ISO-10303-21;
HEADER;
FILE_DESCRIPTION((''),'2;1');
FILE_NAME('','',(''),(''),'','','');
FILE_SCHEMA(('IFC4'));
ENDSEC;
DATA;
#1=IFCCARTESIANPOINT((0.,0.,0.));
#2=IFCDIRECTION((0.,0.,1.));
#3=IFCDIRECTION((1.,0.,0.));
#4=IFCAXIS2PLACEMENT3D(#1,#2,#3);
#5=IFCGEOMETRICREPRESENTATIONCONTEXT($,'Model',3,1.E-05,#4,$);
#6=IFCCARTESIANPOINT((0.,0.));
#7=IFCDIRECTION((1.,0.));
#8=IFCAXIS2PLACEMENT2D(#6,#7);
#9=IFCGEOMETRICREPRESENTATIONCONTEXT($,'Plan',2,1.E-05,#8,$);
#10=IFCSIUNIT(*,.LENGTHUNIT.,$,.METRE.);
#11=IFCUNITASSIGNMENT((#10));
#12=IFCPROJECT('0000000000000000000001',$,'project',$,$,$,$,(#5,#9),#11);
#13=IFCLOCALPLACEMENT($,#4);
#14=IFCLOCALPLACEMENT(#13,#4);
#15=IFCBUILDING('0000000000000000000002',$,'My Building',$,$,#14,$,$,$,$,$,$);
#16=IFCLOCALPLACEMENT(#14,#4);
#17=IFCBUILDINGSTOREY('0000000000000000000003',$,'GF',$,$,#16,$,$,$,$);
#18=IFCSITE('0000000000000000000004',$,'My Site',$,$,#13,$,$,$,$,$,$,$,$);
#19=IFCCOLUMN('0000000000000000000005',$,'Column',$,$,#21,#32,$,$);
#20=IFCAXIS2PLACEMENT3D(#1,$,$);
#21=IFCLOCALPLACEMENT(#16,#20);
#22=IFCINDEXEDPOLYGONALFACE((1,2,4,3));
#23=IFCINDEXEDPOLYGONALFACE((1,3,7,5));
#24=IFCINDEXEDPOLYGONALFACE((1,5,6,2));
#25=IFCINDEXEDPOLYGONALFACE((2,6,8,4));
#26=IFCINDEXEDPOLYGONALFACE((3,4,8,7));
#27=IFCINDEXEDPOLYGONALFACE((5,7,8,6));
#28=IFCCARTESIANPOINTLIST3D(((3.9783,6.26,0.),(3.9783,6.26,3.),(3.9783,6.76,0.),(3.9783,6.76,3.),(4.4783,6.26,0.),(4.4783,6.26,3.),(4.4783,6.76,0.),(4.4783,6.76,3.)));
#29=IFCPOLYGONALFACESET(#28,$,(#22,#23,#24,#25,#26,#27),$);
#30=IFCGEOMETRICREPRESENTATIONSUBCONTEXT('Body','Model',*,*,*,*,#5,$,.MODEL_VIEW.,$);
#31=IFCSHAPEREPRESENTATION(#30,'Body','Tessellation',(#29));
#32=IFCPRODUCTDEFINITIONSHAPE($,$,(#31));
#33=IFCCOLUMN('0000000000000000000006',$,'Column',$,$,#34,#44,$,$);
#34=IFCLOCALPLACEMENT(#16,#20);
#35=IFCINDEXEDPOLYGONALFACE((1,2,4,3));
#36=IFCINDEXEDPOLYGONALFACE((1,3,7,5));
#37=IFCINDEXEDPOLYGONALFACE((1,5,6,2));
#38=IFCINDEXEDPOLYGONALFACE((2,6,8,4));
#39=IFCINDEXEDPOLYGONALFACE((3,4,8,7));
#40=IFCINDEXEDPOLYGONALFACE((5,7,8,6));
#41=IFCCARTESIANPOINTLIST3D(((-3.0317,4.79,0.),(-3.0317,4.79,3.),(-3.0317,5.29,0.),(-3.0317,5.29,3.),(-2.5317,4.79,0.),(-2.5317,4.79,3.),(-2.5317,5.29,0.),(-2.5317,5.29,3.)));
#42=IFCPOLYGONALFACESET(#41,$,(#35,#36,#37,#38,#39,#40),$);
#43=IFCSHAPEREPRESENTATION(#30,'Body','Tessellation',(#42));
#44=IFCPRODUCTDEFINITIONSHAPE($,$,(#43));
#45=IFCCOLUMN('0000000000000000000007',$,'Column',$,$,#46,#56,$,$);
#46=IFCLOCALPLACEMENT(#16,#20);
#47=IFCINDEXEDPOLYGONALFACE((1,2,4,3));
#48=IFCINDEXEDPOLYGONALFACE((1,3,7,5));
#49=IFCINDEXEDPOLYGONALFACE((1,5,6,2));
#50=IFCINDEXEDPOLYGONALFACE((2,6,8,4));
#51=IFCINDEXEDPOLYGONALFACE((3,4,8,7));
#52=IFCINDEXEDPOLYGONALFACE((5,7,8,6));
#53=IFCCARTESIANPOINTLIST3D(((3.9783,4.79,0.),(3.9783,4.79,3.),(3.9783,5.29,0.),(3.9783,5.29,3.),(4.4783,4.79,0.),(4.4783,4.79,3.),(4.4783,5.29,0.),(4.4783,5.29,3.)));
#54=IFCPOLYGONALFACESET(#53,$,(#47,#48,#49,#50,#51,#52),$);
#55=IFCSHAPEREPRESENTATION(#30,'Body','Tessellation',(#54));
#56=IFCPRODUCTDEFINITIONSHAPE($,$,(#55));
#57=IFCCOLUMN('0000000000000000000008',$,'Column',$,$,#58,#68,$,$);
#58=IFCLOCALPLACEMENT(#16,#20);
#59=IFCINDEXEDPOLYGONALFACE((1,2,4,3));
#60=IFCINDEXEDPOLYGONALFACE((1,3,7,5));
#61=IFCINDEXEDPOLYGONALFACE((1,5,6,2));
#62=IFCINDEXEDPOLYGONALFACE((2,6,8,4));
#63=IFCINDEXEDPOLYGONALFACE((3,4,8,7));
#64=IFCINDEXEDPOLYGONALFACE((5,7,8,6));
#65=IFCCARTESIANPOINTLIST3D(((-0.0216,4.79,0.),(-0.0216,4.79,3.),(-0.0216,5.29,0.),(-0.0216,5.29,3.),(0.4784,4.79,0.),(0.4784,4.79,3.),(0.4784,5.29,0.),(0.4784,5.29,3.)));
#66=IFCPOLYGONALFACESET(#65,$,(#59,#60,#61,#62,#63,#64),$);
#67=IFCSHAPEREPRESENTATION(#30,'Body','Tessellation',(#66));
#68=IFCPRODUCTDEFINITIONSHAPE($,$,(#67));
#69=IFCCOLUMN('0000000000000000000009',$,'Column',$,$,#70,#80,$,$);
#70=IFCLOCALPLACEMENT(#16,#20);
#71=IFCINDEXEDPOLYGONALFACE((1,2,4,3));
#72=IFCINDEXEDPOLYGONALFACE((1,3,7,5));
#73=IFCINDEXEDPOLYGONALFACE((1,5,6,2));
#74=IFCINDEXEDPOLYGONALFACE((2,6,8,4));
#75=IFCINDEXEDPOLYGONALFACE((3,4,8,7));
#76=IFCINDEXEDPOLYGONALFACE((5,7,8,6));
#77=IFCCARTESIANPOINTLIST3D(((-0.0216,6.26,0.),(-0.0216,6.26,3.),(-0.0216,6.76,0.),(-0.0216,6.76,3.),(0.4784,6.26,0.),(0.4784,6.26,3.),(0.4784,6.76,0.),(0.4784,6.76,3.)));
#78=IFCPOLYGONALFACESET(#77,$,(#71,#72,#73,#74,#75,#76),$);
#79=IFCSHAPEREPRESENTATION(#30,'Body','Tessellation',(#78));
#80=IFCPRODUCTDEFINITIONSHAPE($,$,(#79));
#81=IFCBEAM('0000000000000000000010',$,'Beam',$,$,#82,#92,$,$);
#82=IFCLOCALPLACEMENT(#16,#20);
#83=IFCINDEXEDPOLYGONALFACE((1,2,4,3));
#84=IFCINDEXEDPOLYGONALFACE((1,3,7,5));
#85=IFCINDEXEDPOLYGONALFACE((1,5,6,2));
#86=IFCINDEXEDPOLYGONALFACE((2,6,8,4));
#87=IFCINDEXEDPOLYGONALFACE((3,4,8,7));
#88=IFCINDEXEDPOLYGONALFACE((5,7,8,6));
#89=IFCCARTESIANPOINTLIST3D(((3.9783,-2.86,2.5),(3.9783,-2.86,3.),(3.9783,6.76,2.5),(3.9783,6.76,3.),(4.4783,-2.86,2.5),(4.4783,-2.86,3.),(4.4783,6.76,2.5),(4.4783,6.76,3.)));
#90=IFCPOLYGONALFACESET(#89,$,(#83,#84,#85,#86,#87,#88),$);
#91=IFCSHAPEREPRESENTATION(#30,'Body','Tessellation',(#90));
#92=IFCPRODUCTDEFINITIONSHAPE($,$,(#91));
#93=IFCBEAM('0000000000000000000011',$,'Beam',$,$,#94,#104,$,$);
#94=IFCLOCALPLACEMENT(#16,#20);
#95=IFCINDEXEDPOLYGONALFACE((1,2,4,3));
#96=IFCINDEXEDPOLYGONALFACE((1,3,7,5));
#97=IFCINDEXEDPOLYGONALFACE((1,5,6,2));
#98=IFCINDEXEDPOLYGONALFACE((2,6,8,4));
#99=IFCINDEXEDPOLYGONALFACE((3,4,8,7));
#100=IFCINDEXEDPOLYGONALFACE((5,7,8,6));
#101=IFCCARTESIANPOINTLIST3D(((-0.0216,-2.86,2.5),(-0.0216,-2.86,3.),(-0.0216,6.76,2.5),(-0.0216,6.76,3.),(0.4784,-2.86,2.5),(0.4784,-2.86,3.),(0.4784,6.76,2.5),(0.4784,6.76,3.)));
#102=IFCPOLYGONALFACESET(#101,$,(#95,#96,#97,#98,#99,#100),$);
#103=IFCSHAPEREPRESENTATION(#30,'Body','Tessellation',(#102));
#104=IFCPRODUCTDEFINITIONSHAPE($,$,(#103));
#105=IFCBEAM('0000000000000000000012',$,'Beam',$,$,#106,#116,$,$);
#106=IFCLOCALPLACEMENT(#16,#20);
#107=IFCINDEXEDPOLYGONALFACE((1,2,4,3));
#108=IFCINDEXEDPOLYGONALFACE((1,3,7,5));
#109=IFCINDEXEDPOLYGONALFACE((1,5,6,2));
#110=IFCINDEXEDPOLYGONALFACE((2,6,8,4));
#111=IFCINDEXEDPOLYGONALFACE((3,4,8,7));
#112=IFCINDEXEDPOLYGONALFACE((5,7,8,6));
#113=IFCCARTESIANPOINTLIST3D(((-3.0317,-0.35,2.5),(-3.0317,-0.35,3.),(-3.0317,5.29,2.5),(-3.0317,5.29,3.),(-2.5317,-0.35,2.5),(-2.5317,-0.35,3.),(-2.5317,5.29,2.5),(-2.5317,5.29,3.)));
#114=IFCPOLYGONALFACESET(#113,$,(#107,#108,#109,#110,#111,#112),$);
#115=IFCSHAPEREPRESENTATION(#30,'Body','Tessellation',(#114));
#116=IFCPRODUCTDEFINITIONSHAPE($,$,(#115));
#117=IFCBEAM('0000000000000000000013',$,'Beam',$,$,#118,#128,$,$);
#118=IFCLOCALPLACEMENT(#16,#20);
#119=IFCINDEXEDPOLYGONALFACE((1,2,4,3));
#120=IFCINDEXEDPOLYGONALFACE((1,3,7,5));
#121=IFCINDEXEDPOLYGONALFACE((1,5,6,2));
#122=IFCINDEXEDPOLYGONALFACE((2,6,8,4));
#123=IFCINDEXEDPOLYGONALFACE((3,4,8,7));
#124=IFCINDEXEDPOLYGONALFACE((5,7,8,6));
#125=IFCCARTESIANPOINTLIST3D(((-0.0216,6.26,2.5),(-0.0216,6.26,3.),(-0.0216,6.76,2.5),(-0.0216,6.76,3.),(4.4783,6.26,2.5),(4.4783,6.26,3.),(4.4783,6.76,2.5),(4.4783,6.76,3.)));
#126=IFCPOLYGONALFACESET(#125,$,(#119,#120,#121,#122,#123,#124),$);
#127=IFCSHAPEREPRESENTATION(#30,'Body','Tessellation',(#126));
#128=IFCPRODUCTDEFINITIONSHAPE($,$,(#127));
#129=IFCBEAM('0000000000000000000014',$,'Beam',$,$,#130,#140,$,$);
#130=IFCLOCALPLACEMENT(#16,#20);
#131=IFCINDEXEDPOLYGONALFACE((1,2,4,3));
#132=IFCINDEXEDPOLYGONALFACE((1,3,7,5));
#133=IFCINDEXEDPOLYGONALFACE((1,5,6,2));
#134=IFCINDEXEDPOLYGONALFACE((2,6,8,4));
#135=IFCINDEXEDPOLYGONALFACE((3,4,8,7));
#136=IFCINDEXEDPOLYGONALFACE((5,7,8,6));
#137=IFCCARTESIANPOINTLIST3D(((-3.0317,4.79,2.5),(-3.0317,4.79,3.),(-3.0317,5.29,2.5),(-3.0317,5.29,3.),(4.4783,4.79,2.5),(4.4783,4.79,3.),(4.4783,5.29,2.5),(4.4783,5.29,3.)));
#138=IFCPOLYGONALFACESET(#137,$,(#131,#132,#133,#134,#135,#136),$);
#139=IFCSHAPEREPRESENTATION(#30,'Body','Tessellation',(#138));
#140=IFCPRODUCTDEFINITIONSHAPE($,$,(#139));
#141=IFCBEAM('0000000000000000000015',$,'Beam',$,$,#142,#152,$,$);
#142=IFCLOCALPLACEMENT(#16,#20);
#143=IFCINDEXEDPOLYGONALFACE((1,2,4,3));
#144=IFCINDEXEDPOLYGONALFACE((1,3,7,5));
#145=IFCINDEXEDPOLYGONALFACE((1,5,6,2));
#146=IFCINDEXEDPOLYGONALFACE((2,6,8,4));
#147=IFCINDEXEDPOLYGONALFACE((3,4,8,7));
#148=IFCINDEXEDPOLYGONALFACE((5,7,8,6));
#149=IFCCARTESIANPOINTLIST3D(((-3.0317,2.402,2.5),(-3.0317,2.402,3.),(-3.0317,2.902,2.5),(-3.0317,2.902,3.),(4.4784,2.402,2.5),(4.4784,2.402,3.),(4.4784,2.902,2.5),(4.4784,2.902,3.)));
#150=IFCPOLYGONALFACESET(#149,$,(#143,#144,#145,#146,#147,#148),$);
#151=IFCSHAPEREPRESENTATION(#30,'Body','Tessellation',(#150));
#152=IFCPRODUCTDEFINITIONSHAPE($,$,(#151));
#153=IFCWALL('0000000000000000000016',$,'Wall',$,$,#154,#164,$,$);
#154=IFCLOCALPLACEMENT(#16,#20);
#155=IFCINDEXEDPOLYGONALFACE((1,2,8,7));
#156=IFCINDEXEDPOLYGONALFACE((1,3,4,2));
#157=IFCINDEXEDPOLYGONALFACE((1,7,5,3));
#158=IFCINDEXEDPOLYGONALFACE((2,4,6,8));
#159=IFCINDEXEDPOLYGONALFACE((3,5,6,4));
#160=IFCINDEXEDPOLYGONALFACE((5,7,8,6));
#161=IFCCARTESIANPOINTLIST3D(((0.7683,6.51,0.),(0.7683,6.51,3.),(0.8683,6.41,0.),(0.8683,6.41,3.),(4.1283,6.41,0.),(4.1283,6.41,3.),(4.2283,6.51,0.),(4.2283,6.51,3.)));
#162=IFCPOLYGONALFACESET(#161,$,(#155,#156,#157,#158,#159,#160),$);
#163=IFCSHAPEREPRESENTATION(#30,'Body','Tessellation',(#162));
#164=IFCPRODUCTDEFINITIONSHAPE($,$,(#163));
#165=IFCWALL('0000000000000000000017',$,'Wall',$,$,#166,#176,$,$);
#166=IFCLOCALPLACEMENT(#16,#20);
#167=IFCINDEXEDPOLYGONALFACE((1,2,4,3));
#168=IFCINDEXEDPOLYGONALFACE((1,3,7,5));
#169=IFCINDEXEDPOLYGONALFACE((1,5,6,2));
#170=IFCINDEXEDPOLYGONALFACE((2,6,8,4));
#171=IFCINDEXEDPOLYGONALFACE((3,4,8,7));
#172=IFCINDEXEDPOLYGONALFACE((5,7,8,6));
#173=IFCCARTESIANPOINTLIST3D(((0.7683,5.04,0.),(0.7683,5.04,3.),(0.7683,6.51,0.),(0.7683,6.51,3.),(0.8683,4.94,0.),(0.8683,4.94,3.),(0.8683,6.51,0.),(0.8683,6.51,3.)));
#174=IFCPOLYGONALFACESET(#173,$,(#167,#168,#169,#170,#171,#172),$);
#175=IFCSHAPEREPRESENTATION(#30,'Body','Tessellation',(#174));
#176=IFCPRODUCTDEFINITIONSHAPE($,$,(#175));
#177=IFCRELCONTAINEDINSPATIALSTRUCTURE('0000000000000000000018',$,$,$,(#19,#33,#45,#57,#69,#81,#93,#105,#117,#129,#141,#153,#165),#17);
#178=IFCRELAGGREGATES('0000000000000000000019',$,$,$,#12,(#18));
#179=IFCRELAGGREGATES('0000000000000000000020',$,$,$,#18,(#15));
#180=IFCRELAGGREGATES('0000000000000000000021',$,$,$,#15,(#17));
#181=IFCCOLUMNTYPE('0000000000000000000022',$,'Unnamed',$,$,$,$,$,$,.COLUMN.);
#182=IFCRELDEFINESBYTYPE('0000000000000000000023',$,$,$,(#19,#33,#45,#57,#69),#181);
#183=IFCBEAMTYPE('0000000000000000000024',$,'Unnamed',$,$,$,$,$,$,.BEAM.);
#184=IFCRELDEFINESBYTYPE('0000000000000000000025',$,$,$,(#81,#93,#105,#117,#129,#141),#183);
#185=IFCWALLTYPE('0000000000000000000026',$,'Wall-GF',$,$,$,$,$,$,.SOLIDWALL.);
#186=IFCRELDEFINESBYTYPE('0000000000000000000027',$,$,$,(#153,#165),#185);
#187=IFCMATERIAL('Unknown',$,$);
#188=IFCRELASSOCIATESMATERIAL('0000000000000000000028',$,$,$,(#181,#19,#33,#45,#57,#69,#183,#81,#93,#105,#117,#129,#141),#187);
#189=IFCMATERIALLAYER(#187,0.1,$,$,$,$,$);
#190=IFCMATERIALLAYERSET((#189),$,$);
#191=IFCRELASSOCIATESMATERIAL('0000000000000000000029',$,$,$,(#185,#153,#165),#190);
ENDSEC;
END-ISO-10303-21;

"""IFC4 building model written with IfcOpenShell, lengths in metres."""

from ifc_helpers import new_model, si_unit, frame, origin_with_axes, origin_2d_with_axis, place, context, subcontext, project, spatial, line, indexed_curve, rectangle, outline, extrude, material, layer, layer_set, layer_usage, material_profile, profile_set, profile_usage, type_object, element, save


model = new_model("IFC4")

# Units and contexts
model_context = context("Model", 3, precision=1e-05, world=origin_with_axes())
plan_context = context("Plan", 2, precision=1e-05, world=origin_2d_with_axis())
body_context_1 = subcontext(model_context, "Body", "Model", "MODEL_VIEW")
ifc_project = project(units=[si_unit("LENGTHUNIT", "METRE")], contexts=[model_context, plan_context])

# Site, building, storey
site_placement = place(None, origin_with_axes())
site = spatial("IfcSite", under=ifc_project, at=site_placement, Name="My Site")
building_placement = place(site_placement, origin_with_axes())
building = spatial("IfcBuilding", under=site, at=building_placement, Name="My Building")
storey_placement = place(building_placement, origin_with_axes())
storey = spatial("IfcBuildingStorey", under=building, at=storey_placement, Name="GF")

# Columns
ifc_material_1 = material(Name="Unknown")
ifc_material_profile_1 = material_profile(ifc_material_1, rectangle(XDim=0.5, YDim=0.5))
ifc_profile_set_1 = profile_set([ifc_material_profile_1])
ifc_profile_usage_1 = profile_usage(ifc_profile_set_1, cardinal=5)
column_type = type_object("IfcColumnType", Name="Unnamed", PredefinedType="COLUMN", material=ifc_profile_set_1)
column_1_placement = place(storey_placement, frame((4.2283, 6.51, 0.0), z_axis=(0.0, 0.0, 1.0), x_axis=(1.0, 0.0, 0.0)))
element("IfcColumn", 1, at=column_1_placement, inside=storey, type_object=column_type, material=ifc_profile_usage_1, Name="Column", context=body_context_1, shape_type="SweptSolid", body=[
    extrude(rectangle(XDim=0.5, YDim=0.5), origin_with_axes(), (0.0, 0.0, 1.0), 3.0),
])
ifc_profile_usage_2 = profile_usage(ifc_profile_set_1, cardinal=5)
column_2_placement = place(storey_placement, frame((-2.7817, 5.04, 0.0), z_axis=(0.0, 0.0, 1.0), x_axis=(1.0, 0.0, 0.0)))
element("IfcColumn", 2, at=column_2_placement, inside=storey, type_object=column_type, material=ifc_profile_usage_2, Name="Column", context=body_context_1, shape_type="SweptSolid", body=[
    extrude(rectangle(XDim=0.5, YDim=0.5), origin_with_axes(), (0.0, 0.0, 1.0), 3.0),
])
ifc_profile_usage_3 = profile_usage(ifc_profile_set_1, cardinal=5)
column_3_placement = place(storey_placement, frame((4.2283, 5.04, 0.0), z_axis=(0.0, 0.0, 1.0), x_axis=(1.0, 0.0, 0.0)))
element("IfcColumn", 3, at=column_3_placement, inside=storey, type_object=column_type, material=ifc_profile_usage_3, Name="Column", context=body_context_1, shape_type="SweptSolid", body=[
    extrude(rectangle(XDim=0.5, YDim=0.5), origin_with_axes(), (0.0, 0.0, 1.0), 3.0),
])
ifc_profile_usage_4 = profile_usage(ifc_profile_set_1, cardinal=5)
column_4_placement = place(storey_placement, frame((0.2284, 5.04, 0.0), z_axis=(0.0, 0.0, 1.0), x_axis=(1.0, 0.0, 0.0)))
element("IfcColumn", 4, at=column_4_placement, inside=storey, type_object=column_type, material=ifc_profile_usage_4, Name="Column", context=body_context_1, shape_type="SweptSolid", body=[
    extrude(rectangle(XDim=0.5, YDim=0.5), origin_with_axes(), (0.0, 0.0, 1.0), 3.0),
])
ifc_profile_usage_5 = profile_usage(ifc_profile_set_1, cardinal=5)
column_5_placement = place(storey_placement, frame((0.2284, 6.51, 0.0), z_axis=(0.0, 0.0, 1.0), x_axis=(1.0, 0.0, 0.0)))
element("IfcColumn", 5, at=column_5_placement, inside=storey, type_object=column_type, material=ifc_profile_usage_5, Name="Column", context=body_context_1, shape_type="SweptSolid", body=[
    extrude(rectangle(XDim=0.5, YDim=0.5), origin_with_axes(), (0.0, 0.0, 1.0), 3.0),
])

# Beams
ifc_material_profile_2 = material_profile(ifc_material_1, rectangle(XDim=0.5, YDim=0.5))
ifc_profile_set_2 = profile_set([ifc_material_profile_2])
ifc_profile_usage_6 = profile_usage(ifc_profile_set_2, cardinal=7)
beam_type = type_object("IfcBeamType", Name="Unnamed", PredefinedType="BEAM", material=ifc_profile_set_2)
beam_1_placement = place(storey_placement, frame((4.4783, 6.76, 3.0), z_axis=(0.0, -1.0, 0.0), x_axis=(1.0, 0.0, 0.0)))
element("IfcBeam", 6, at=beam_1_placement, inside=storey, type_object=beam_type, material=ifc_profile_usage_6, Name="Beam", context=body_context_1, shape_type="SweptSolid", body=[
    extrude(rectangle(XDim=0.5, YDim=0.5), frame((-0.25, -0.25, 0.0), z_axis=(0.0, 0.0, 1.0), x_axis=(1.0, 0.0, 0.0)), (0.0, 0.0, 1.0), 9.62),
])
ifc_profile_usage_7 = profile_usage(ifc_profile_set_2, cardinal=7)
beam_2_placement = place(storey_placement, frame((0.4784, 6.76, 3.0), z_axis=(0.0, -1.0, 0.0), x_axis=(1.0, 0.0, 0.0)))
element("IfcBeam", 7, at=beam_2_placement, inside=storey, type_object=beam_type, material=ifc_profile_usage_7, Name="Beam", context=body_context_1, shape_type="SweptSolid", body=[
    extrude(rectangle(XDim=0.5, YDim=0.5), frame((-0.25, -0.25, 0.0), z_axis=(0.0, 0.0, 1.0), x_axis=(1.0, 0.0, 0.0)), (0.0, 0.0, 1.0), 9.62),
])
ifc_profile_usage_8 = profile_usage(ifc_profile_set_2, cardinal=7)
beam_3_placement = place(storey_placement, frame((-2.5317, 5.29, 3.0), z_axis=(0.0, -1.0, 0.0), x_axis=(1.0, 0.0, 0.0)))
element("IfcBeam", 8, at=beam_3_placement, inside=storey, type_object=beam_type, material=ifc_profile_usage_8, Name="Beam", context=body_context_1, shape_type="SweptSolid", body=[
    extrude(rectangle(XDim=0.5, YDim=0.5), frame((-0.25, -0.25, 0.0), z_axis=(0.0, 0.0, 1.0), x_axis=(1.0, 0.0, 0.0)), (0.0, 0.0, 1.0), 5.64),
])
ifc_profile_usage_9 = profile_usage(ifc_profile_set_2, cardinal=7)
beam_4_placement = place(storey_placement, frame((-0.0216, 6.76, 3.0), z_axis=(1.0, 0.0, 0.0), x_axis=(0.0, 1.0, 0.0)))
element("IfcBeam", 9, at=beam_4_placement, inside=storey, type_object=beam_type, material=ifc_profile_usage_9, Name="Beam", context=body_context_1, shape_type="SweptSolid", body=[
    extrude(rectangle(XDim=0.5, YDim=0.5), frame((-0.25, -0.25, 0.0), z_axis=(0.0, 0.0, 1.0), x_axis=(1.0, 0.0, 0.0)), (0.0, 0.0, 1.0), 4.5),
])
ifc_profile_usage_10 = profile_usage(ifc_profile_set_2, cardinal=7)
beam_5_placement = place(storey_placement, frame((-3.0317, 5.29, 3.0), z_axis=(1.0, 0.0, 0.0), x_axis=(0.0, 1.0, 0.0)))
element("IfcBeam", 10, at=beam_5_placement, inside=storey, type_object=beam_type, material=ifc_profile_usage_10, Name="Beam", context=body_context_1, shape_type="SweptSolid", body=[
    extrude(rectangle(XDim=0.5, YDim=0.5), frame((-0.25, -0.25, 0.0), z_axis=(0.0, 0.0, 1.0), x_axis=(1.0, 0.0, 0.0)), (0.0, 0.0, 1.0), 7.51),
])
ifc_profile_usage_11 = profile_usage(ifc_profile_set_2, cardinal=7)
beam_6_placement = place(storey_placement, frame((-3.0317, 2.902, 3.0), z_axis=(1.0, -0.000001, 0.000001), x_axis=(0.000001, 1.0, 0.0)))
element("IfcBeam", 11, at=beam_6_placement, inside=storey, type_object=beam_type, material=ifc_profile_usage_11, Name="Beam", context=body_context_1, shape_type="SweptSolid", body=[
    extrude(rectangle(XDim=0.5, YDim=0.5), frame((-0.25, -0.25, 0.0), z_axis=(0.0, 0.0, 1.0), x_axis=(1.0, 0.0, 0.0)), (0.0, 0.0, 1.0), 7.51),
])

# Walls
ifc_layer_1 = layer(ifc_material_1, 0.1)
ifc_layer_set_1 = layer_set([ifc_layer_1])
ifc_layer_usage_1 = layer_usage(ifc_layer_set_1, "AXIS2", "POSITIVE", 0.0)
wall_type = type_object("IfcWallType", Name="Wall-GF", PredefinedType="SOLIDWALL", material=ifc_layer_set_1)
wall_1_placement = place(storey_placement, frame((4.2283, 6.51, 0.0), z_axis=(0.0, 0.0, 1.0), x_axis=(-1.0, 0.0, 0.0)))
element("IfcWall", 12, at=wall_1_placement, inside=storey, type_object=wall_type, material=ifc_layer_usage_1, Name="Wall", context=body_context_1, shape_type="SweptSolid", body=[
    extrude(outline(indexed_curve([(0.0, 0.0), (0.1, 0.1), (3.36, 0.1), (3.46, 0.0)], segments=[line(1, 2, 3, 4, 1)])), origin_with_axes(), (0.0, 0.0, 1.0), 3.0),
])
ifc_layer_usage_2 = layer_usage(ifc_layer_set_1, "AXIS2", "POSITIVE", 0.0)
wall_2_placement = place(storey_placement, frame((0.7683, 6.51, 0.0), z_axis=(0.0, 0.0, 1.0), x_axis=(0.0, -1.0, 0.0)))
element("IfcWall", 13, at=wall_2_placement, inside=storey, type_object=wall_type, material=ifc_layer_usage_2, Name="Wall", context=body_context_1, shape_type="SweptSolid", body=[
    extrude(outline(indexed_curve([(0.0, 0.0), (0.0, 0.1), (1.57, 0.1), (1.47, 0.0)], segments=[line(1, 2, 3, 4, 1)])), origin_with_axes(), (0.0, 0.0, 1.0), 3.0),
])

save(model, "model.ifc")
